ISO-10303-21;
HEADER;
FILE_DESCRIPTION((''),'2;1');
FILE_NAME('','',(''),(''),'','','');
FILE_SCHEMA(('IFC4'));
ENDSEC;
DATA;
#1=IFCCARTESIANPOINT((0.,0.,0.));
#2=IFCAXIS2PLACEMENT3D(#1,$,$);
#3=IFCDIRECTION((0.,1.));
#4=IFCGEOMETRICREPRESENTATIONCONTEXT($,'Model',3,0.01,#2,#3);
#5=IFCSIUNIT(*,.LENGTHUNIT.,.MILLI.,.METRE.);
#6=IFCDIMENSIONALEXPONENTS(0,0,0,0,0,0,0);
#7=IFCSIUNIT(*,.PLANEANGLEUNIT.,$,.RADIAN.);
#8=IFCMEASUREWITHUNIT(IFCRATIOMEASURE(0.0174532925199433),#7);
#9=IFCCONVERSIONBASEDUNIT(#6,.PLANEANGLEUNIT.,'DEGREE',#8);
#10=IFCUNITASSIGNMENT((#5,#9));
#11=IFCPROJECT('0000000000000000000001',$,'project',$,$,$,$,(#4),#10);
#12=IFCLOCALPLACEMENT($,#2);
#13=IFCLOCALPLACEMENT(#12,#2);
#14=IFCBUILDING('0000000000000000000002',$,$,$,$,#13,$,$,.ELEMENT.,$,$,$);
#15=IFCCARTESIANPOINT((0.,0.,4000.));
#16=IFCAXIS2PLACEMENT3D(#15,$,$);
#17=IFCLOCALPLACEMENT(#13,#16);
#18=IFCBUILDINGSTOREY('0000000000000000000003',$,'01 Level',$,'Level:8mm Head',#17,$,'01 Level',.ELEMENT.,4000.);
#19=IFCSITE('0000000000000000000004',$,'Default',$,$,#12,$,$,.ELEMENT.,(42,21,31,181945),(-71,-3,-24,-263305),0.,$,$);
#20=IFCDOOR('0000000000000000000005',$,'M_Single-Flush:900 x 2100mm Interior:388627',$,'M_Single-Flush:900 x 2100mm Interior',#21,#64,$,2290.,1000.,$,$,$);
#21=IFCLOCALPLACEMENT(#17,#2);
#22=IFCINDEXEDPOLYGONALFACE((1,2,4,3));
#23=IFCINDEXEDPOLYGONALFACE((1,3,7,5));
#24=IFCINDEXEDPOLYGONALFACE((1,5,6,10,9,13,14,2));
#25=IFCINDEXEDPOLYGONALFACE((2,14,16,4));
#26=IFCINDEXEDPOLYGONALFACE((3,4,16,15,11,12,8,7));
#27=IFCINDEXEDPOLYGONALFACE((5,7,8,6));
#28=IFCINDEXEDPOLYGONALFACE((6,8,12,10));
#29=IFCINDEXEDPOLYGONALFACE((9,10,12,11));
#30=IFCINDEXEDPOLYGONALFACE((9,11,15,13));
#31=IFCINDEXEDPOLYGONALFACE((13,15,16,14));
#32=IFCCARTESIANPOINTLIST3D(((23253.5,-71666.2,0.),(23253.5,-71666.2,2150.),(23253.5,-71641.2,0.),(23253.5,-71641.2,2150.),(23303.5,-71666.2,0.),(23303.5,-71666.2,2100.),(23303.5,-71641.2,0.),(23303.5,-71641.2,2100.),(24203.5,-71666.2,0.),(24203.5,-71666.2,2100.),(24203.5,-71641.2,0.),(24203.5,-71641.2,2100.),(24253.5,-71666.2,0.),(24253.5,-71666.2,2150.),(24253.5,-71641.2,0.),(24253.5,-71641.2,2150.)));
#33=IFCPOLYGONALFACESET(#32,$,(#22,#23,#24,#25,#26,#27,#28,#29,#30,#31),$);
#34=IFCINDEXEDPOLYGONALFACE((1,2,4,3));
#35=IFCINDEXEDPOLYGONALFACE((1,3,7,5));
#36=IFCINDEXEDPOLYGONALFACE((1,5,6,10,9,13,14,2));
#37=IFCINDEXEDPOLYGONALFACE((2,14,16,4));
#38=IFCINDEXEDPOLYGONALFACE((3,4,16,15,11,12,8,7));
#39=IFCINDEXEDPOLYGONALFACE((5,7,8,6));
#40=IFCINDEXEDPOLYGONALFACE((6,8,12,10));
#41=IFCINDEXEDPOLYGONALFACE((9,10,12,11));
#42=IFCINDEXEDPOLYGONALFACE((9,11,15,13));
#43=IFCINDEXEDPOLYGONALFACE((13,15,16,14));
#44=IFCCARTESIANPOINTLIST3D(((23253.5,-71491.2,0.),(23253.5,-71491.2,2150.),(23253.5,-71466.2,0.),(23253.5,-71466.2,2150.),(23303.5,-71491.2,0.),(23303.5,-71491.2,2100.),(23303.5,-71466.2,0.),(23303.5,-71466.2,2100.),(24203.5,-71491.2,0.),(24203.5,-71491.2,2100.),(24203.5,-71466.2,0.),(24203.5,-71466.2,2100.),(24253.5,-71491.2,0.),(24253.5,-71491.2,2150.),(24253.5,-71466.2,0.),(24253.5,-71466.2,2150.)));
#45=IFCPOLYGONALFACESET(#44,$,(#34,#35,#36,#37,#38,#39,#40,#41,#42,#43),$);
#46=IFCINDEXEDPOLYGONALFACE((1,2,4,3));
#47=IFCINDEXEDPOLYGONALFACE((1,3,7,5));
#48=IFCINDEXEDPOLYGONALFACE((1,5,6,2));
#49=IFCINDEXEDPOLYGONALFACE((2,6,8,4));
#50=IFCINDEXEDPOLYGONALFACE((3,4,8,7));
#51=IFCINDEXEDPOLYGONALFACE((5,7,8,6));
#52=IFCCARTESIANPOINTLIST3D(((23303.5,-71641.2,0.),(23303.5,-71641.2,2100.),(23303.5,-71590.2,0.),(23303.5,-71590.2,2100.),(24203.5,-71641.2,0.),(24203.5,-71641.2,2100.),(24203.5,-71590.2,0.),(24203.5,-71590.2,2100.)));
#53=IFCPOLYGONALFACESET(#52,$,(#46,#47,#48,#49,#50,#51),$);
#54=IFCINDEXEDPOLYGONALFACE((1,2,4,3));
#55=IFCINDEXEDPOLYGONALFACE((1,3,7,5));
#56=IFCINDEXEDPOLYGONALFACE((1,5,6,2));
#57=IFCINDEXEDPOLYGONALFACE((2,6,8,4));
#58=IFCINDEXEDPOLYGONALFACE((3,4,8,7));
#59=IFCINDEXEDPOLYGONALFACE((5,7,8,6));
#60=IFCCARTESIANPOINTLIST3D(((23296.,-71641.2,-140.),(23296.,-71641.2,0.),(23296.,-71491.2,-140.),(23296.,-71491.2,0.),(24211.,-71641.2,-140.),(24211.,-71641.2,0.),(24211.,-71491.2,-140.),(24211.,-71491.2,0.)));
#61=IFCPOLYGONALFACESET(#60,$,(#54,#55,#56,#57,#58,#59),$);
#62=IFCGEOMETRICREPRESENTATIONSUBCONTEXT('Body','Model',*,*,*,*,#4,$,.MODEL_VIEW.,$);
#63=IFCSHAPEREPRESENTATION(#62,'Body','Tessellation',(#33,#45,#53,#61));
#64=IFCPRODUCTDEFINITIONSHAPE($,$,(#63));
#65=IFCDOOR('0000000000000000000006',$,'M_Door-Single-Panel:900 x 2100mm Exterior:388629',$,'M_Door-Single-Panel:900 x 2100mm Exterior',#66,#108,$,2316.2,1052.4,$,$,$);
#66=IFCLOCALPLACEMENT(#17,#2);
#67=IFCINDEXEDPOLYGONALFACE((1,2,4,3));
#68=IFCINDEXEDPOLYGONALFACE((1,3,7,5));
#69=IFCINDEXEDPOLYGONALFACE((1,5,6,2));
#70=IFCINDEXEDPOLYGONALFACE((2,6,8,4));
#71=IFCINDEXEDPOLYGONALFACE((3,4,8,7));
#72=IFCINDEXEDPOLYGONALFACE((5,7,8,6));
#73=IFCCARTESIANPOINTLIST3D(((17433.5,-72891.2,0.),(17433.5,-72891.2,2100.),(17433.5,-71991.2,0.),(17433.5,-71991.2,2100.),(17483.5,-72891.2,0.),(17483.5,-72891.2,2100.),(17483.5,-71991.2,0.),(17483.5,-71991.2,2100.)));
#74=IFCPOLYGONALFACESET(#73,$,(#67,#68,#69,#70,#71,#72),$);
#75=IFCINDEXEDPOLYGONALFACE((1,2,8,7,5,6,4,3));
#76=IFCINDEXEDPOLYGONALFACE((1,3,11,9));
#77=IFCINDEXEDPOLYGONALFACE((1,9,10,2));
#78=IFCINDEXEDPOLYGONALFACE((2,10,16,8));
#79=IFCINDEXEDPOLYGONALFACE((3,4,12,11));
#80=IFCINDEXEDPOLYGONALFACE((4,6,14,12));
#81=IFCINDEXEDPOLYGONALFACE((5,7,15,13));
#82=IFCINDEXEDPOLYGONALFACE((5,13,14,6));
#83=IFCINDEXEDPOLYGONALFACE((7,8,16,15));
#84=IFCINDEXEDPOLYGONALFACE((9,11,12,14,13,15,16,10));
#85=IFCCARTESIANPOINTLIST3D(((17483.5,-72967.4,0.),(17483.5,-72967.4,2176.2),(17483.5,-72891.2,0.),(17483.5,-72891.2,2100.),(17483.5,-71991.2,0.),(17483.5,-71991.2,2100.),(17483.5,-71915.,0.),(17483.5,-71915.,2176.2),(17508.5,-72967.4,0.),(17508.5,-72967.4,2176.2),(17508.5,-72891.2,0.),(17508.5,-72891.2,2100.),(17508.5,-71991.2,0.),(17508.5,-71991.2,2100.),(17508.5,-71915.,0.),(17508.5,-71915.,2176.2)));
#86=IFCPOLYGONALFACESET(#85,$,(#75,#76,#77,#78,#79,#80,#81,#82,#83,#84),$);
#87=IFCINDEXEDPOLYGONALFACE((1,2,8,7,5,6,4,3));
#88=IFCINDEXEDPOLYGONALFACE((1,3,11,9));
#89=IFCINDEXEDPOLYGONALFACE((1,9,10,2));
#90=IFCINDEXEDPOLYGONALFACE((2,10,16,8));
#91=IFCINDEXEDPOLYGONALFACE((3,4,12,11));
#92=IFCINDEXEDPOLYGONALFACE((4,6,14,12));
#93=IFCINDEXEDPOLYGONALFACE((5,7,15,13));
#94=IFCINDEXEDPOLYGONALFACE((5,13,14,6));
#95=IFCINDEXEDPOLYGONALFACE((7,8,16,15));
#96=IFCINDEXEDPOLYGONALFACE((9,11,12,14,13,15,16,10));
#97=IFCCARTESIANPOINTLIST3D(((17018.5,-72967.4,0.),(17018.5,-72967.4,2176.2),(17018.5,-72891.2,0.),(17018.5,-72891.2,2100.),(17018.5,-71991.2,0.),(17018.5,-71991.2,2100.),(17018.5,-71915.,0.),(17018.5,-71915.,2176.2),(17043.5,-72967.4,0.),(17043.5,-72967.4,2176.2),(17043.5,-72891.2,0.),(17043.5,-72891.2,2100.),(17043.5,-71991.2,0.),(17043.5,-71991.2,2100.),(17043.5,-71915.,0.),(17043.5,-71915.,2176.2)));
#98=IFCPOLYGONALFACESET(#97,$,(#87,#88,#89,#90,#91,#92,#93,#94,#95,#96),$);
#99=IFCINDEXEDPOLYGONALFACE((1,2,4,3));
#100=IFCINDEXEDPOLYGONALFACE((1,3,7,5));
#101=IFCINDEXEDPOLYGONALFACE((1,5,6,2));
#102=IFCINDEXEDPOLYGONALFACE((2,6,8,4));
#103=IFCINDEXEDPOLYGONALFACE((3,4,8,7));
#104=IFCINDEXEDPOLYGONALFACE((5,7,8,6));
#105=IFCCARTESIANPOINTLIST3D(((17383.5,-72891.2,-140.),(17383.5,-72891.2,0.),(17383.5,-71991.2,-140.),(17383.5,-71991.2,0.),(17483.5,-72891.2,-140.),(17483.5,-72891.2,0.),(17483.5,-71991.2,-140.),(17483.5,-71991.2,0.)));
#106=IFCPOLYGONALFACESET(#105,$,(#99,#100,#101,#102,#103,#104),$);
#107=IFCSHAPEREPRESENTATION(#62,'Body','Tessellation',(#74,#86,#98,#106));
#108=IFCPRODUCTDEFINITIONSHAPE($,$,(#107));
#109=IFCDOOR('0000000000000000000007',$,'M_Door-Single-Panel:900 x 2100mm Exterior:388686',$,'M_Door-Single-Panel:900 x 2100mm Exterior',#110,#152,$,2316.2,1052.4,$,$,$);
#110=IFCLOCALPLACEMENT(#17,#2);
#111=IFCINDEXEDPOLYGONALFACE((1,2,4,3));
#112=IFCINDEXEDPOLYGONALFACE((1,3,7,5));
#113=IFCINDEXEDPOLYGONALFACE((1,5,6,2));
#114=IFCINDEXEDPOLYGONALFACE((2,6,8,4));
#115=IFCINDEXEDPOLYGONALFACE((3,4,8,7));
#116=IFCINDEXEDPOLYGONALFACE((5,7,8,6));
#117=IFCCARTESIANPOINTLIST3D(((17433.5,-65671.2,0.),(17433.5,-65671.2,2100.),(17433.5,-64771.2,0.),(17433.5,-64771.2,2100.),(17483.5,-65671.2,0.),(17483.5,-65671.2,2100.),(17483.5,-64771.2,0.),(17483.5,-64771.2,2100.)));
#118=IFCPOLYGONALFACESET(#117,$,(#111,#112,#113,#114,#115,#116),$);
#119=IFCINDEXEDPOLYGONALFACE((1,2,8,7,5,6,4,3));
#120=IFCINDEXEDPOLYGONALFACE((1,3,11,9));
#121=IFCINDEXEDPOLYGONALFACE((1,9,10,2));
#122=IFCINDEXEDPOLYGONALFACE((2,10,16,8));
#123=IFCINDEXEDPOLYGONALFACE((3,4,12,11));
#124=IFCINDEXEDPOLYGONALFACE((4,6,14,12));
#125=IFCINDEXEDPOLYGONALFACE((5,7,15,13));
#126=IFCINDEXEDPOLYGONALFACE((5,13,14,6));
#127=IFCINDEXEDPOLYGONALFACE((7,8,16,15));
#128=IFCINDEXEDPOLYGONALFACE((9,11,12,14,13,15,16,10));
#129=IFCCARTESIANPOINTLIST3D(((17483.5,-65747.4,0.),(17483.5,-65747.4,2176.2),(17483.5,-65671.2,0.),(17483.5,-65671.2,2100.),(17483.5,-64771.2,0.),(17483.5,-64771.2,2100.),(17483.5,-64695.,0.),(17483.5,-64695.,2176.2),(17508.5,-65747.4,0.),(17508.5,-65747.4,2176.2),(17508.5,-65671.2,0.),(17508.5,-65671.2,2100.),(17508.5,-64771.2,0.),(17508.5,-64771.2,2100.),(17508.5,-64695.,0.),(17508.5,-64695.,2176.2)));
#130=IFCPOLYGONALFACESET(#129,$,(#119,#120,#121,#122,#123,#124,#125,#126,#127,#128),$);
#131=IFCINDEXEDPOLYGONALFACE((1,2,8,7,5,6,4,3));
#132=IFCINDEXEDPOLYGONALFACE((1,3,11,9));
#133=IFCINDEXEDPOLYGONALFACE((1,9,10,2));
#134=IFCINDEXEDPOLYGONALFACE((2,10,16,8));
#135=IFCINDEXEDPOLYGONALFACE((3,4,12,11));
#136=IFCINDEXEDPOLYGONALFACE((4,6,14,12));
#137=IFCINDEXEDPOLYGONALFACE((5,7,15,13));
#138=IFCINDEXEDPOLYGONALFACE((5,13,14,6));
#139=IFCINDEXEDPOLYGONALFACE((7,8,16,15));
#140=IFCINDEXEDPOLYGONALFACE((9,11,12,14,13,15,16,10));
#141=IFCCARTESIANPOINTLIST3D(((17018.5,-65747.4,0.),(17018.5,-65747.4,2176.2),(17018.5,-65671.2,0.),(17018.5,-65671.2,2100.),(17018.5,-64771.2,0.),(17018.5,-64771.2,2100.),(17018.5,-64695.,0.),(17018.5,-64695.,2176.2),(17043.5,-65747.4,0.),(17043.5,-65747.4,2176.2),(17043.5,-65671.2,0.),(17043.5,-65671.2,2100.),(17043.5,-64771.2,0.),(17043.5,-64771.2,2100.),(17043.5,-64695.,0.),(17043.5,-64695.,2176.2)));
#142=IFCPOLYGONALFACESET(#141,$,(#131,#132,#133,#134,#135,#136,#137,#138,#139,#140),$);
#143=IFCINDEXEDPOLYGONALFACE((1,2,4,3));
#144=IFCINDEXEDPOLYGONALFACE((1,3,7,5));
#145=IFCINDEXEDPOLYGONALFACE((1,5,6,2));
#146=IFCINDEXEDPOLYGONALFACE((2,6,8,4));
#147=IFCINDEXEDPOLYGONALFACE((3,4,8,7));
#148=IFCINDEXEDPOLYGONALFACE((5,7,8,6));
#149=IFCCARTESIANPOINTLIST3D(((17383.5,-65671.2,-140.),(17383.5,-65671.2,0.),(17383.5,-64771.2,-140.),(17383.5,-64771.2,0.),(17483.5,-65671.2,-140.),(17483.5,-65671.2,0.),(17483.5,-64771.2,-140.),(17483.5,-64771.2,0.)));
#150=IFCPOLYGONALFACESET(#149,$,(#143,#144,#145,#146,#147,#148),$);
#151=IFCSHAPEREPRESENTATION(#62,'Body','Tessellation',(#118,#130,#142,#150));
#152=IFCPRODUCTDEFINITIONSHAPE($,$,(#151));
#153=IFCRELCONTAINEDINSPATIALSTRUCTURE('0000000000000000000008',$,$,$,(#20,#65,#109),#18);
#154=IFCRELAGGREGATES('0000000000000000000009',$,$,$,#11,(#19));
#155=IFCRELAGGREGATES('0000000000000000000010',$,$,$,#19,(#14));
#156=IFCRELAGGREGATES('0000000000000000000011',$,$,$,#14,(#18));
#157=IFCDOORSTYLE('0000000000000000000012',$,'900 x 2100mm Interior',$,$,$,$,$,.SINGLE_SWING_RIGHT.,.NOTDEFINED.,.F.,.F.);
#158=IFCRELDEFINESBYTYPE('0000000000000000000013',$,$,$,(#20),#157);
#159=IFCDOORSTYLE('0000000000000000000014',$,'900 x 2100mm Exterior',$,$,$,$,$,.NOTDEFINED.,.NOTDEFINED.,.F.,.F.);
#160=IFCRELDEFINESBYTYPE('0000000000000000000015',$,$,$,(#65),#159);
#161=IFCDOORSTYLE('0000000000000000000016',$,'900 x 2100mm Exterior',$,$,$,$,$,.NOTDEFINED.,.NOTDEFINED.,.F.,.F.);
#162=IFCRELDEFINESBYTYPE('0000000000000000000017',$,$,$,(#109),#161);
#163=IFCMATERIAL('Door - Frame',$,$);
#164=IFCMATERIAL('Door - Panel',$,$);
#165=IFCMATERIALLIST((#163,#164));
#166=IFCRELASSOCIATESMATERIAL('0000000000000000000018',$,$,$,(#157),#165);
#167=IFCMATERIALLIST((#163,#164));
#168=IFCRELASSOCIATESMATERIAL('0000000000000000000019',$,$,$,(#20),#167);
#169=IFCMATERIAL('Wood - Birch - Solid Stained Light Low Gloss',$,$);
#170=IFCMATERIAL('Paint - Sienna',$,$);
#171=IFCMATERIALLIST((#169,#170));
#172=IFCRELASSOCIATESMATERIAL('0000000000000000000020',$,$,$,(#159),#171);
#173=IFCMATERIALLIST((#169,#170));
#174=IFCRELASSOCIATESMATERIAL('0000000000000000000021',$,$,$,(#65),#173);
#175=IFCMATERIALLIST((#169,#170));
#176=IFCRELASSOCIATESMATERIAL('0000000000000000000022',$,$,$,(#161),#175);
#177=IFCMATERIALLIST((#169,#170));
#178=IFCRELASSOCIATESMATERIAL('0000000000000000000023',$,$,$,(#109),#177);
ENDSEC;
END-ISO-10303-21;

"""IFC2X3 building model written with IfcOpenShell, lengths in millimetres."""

from ifc_helpers import new_model, entity, si_unit, converted_unit, direction, frame, frame_2d, origin, origin_2d_with_axis, place, context, subcontext, project, spatial, polyline, rectangle, outline, extrude, source, transform, mapped, material, material_list, type_object, type_shapes, element, save


model = new_model("IFC2X3")

# Units and contexts
model_context = context("Model", 3, precision=0.01, world=origin(), true_north=direction((0.0, 1.0)))
body_context = subcontext(model_context, "Body", "Model", "MODEL_VIEW")
ifc_project = project(units=[si_unit("LENGTHUNIT", "METRE", prefix="MILLI"), converted_unit("PLANEANGLEUNIT", "DEGREE", entity("IfcRatioMeasure", 0.0174532925199433), si_unit("PLANEANGLEUNIT", "RADIAN"), dimensions=[0, 0, 0, 0, 0, 0, 0])], contexts=[model_context])

# Site, building, storey
site_placement = place(None, origin())
site = spatial("IfcSite", under=ifc_project, at=site_placement, Name="Default", CompositionType="ELEMENT", RefLatitude=(42, 21, 31, 181945), RefLongitude=(-71, -3, -24, -263305), RefElevation=0.0)
building_placement = place(site_placement, origin())
building = spatial("IfcBuilding", under=site, at=building_placement, CompositionType="ELEMENT")
storey_placement = place(building_placement, frame((0.0, 0.0, 4000.0)))
storey = spatial("IfcBuildingStorey", under=building, at=storey_placement, Name="01 Level", ObjectType="Level:8mm Head", LongName="01 Level", CompositionType="ELEMENT", Elevation=4000.0)

# Doors
ifc_material_1 = material(Name="Door - Frame")
ifc_material_2 = material(Name="Door - Panel")
ifc_material_list_1 = material_list([ifc_material_1, ifc_material_2])
ifc_material_list_2 = material_list([ifc_material_1, ifc_material_2])
door_style_1 = type_object("IfcDoorStyle", Name="900 x 2100mm Interior", ConstructionType="NOTDEFINED", OperationType="SINGLE_SWING_RIGHT", ParameterTakesPrecedence=False, Sizeable=False, material=ifc_material_list_2)
shared_shape_1 = source(origin(), body_context, "Body", "SweptSolid", [
    extrude(outline(polyline([(-500.0, -1087.5), (500.0, -1087.5), (500.0, 1062.5), (450.0, 1062.5), (450.0, -1037.5), (-450.0, -1037.5), (-450.0, 1062.5), (-500.0, 1062.5), (-500.0, -1087.5)])), frame((450.0, 150.0, 1202.5), z_axis=(0.0, 1.0, 0.0), x_axis=(1.0, 0.0, 0.0)), (0.0, 0.0, 1.0), 25.0),
    extrude(outline(polyline([(-1087.5, -500.0), (1062.5, -500.0), (1062.5, -450.0), (-1037.5, -450.0), (-1037.5, 450.0), (1062.5, 450.0), (1062.5, 500.0), (-1087.5, 500.0), (-1087.5, -500.0)])), frame((450.0, -25.0, 1202.5), z_axis=(0.0, 1.0, 0.0), x_axis=(0.0, 0.0, -1.0)), (0.0, 0.0, 1.0), 25.0),
    extrude(rectangle(XDim=51.0, YDim=900.0, at=frame_2d((0.0, 0.0), x_axis=(1.0, 0.0))), frame((450.0, 124.5, 140.0), z_axis=(0.0, 0.0, 1.0), x_axis=(0.0, 1.0, 0.0)), (0.0, 0.0, 1.0), 2100.0),
    extrude(rectangle(XDim=915.0, YDim=150.0, at=origin_2d_with_axis()), frame((450.0, 75.0, 0.0), z_axis=(0.0, 0.0, 1.0), x_axis=(-1.0, 0.0, 0.0)), (0.0, 0.0, 1.0), 140.0),
])
type_shapes(door_style_1, [shared_shape_1])
door_1_placement = place(storey_placement, frame((24203.5, -71491.2, -140.0), z_axis=(0.0, 0.0, 1.0), x_axis=(-1.0, 0.0, 0.0)))
element("IfcDoor", 1, at=door_1_placement, inside=storey, type_object=door_style_1, material=ifc_material_list_1, Name="M_Single-Flush:900 x 2100mm Interior:388627", ObjectType="M_Single-Flush:900 x 2100mm Interior", OverallHeight=2290.0, OverallWidth=1000.0, context=body_context, shape_type="MappedRepresentation", body=[
    mapped(shared_shape_1, transform((0.0, 0.0, 0.0), scale=1.0)),
])
ifc_material_3 = material(Name="Wood - Birch - Solid Stained Light Low Gloss")
ifc_material_4 = material(Name="Paint - Sienna")
ifc_material_list_3 = material_list([ifc_material_3, ifc_material_4])
ifc_material_list_4 = material_list([ifc_material_3, ifc_material_4])
door_style_2 = type_object("IfcDoorStyle", Name="900 x 2100mm Exterior", ConstructionType="NOTDEFINED", OperationType="NOTDEFINED", ParameterTakesPrecedence=False, Sizeable=False, material=ifc_material_list_4)
shared_shape_2 = source(origin(), body_context, "Body", "SweptSolid", [
    extrude(rectangle(XDim=50.0, YDim=900.0, at=origin_2d_with_axis()), frame((450.0, 415.0, 140.0), z_axis=(0.0, 0.0, 1.0), x_axis=(0.0, 1.0, 0.0)), (0.0, 0.0, 1.0), 2100.0),
    extrude(outline(polyline([(-526.2, -1107.2), (526.2, -1107.2), (526.2, 1069.0), (450.0, 1069.0), (450.0, -1031.0), (-450.0, -1031.0), (-450.0, 1069.0), (-526.2, 1069.0), (-526.2, -1107.2)])), frame((450.0, 440.0, 1209.0), z_axis=(0.0, 1.0, 0.0), x_axis=(1.0, 0.0, 0.0)), (0.0, 0.0, 1.0), 25.0),
    extrude(outline(polyline([(-1107.2, -526.2), (1069.0, -526.2), (1069.0, -450.0), (-1031.0, -450.0), (-1031.0, 450.0), (1069.0, 450.0), (1069.0, 526.2), (-1107.2, 526.2), (-1107.2, -526.2)])), frame((450.0, -25.0, 1209.0), z_axis=(0.0, 1.0, 0.0), x_axis=(0.0, 0.0, -1.0)), (0.0, 0.0, 1.0), 25.0),
    extrude(rectangle(XDim=900.0, YDim=100.0, at=origin_2d_with_axis()), frame((450.0, 390.0, 0.0), z_axis=(0.0, 0.0, 1.0), x_axis=(-1.0, 0.0, 0.0)), (0.0, 0.0, 1.0), 140.0),
])
type_shapes(door_style_2, [shared_shape_2])
door_2_placement = place(storey_placement, frame((17043.5, -71991.2, -140.0), z_axis=(0.0, 0.0, 1.0), x_axis=(0.0, -1.0, 0.0)))
element("IfcDoor", 2, at=door_2_placement, inside=storey, type_object=door_style_2, material=ifc_material_list_3, Name="M_Door-Single-Panel:900 x 2100mm Exterior:388629", ObjectType="M_Door-Single-Panel:900 x 2100mm Exterior", OverallHeight=2316.2, OverallWidth=1052.4, context=body_context, shape_type="MappedRepresentation", body=[
    mapped(shared_shape_2, transform((0.0, 0.0, 0.0), scale=1.0)),
])
ifc_material_list_5 = material_list([ifc_material_3, ifc_material_4])
ifc_material_list_6 = material_list([ifc_material_3, ifc_material_4])
door_style_3 = type_object("IfcDoorStyle", Name="900 x 2100mm Exterior", ConstructionType="NOTDEFINED", OperationType="NOTDEFINED", ParameterTakesPrecedence=False, Sizeable=False, material=ifc_material_list_6)
shared_shape_3 = source(origin(), body_context, "Body", "SweptSolid", [
    extrude(rectangle(XDim=900.0, YDim=50.0, at=origin_2d_with_axis()), frame((450.0, 415.0, 140.0)), (0.0, 0.0, 1.0), 2100.0),
    extrude(outline(polyline([(-526.2, -1107.2), (526.2, -1107.2), (526.2, 1069.0), (450.0, 1069.0), (450.0, -1031.0), (-450.0, -1031.0), (-450.0, 1069.0), (-526.2, 1069.0), (-526.2, -1107.2)])), frame((450.0, 465.0, 1209.0), z_axis=(0.0, -1.0, 0.0), x_axis=(-1.0, 0.0, 0.0)), (0.0, 0.0, 1.0), 25.0),
    extrude(outline(polyline([(-1107.2, -526.2), (1069.0, -526.2), (1069.0, -450.0), (-1031.0, -450.0), (-1031.0, 450.0), (1069.0, 450.0), (1069.0, 526.2), (-1107.2, 526.2), (-1107.2, -526.2)])), frame((450.0, 0.0, 1209.0), z_axis=(0.0, -1.0, 0.0), x_axis=(0.0, 0.0, -1.0)), (0.0, 0.0, 1.0), 25.0),
    extrude(rectangle(XDim=100.0, YDim=900.0, at=origin_2d_with_axis()), frame((450.0, 390.0, 0.0), z_axis=(0.0, 0.0, 1.0), x_axis=(0.0, -1.0, 0.0)), (0.0, 0.0, 1.0), 140.0),
])
type_shapes(door_style_3, [shared_shape_3])
door_3_placement = place(storey_placement, frame((17043.5, -64771.2, -140.0), z_axis=(0.0, 0.0, 1.0), x_axis=(0.0, -1.0, 0.0)))
element("IfcDoor", 3, at=door_3_placement, inside=storey, type_object=door_style_3, material=ifc_material_list_5, Name="M_Door-Single-Panel:900 x 2100mm Exterior:388686", ObjectType="M_Door-Single-Panel:900 x 2100mm Exterior", OverallHeight=2316.2, OverallWidth=1052.4, context=body_context, shape_type="MappedRepresentation", body=[
    mapped(shared_shape_3, transform((0.0, 0.0, 0.0), scale=1.0)),
])

save(model, "model.ifc")
